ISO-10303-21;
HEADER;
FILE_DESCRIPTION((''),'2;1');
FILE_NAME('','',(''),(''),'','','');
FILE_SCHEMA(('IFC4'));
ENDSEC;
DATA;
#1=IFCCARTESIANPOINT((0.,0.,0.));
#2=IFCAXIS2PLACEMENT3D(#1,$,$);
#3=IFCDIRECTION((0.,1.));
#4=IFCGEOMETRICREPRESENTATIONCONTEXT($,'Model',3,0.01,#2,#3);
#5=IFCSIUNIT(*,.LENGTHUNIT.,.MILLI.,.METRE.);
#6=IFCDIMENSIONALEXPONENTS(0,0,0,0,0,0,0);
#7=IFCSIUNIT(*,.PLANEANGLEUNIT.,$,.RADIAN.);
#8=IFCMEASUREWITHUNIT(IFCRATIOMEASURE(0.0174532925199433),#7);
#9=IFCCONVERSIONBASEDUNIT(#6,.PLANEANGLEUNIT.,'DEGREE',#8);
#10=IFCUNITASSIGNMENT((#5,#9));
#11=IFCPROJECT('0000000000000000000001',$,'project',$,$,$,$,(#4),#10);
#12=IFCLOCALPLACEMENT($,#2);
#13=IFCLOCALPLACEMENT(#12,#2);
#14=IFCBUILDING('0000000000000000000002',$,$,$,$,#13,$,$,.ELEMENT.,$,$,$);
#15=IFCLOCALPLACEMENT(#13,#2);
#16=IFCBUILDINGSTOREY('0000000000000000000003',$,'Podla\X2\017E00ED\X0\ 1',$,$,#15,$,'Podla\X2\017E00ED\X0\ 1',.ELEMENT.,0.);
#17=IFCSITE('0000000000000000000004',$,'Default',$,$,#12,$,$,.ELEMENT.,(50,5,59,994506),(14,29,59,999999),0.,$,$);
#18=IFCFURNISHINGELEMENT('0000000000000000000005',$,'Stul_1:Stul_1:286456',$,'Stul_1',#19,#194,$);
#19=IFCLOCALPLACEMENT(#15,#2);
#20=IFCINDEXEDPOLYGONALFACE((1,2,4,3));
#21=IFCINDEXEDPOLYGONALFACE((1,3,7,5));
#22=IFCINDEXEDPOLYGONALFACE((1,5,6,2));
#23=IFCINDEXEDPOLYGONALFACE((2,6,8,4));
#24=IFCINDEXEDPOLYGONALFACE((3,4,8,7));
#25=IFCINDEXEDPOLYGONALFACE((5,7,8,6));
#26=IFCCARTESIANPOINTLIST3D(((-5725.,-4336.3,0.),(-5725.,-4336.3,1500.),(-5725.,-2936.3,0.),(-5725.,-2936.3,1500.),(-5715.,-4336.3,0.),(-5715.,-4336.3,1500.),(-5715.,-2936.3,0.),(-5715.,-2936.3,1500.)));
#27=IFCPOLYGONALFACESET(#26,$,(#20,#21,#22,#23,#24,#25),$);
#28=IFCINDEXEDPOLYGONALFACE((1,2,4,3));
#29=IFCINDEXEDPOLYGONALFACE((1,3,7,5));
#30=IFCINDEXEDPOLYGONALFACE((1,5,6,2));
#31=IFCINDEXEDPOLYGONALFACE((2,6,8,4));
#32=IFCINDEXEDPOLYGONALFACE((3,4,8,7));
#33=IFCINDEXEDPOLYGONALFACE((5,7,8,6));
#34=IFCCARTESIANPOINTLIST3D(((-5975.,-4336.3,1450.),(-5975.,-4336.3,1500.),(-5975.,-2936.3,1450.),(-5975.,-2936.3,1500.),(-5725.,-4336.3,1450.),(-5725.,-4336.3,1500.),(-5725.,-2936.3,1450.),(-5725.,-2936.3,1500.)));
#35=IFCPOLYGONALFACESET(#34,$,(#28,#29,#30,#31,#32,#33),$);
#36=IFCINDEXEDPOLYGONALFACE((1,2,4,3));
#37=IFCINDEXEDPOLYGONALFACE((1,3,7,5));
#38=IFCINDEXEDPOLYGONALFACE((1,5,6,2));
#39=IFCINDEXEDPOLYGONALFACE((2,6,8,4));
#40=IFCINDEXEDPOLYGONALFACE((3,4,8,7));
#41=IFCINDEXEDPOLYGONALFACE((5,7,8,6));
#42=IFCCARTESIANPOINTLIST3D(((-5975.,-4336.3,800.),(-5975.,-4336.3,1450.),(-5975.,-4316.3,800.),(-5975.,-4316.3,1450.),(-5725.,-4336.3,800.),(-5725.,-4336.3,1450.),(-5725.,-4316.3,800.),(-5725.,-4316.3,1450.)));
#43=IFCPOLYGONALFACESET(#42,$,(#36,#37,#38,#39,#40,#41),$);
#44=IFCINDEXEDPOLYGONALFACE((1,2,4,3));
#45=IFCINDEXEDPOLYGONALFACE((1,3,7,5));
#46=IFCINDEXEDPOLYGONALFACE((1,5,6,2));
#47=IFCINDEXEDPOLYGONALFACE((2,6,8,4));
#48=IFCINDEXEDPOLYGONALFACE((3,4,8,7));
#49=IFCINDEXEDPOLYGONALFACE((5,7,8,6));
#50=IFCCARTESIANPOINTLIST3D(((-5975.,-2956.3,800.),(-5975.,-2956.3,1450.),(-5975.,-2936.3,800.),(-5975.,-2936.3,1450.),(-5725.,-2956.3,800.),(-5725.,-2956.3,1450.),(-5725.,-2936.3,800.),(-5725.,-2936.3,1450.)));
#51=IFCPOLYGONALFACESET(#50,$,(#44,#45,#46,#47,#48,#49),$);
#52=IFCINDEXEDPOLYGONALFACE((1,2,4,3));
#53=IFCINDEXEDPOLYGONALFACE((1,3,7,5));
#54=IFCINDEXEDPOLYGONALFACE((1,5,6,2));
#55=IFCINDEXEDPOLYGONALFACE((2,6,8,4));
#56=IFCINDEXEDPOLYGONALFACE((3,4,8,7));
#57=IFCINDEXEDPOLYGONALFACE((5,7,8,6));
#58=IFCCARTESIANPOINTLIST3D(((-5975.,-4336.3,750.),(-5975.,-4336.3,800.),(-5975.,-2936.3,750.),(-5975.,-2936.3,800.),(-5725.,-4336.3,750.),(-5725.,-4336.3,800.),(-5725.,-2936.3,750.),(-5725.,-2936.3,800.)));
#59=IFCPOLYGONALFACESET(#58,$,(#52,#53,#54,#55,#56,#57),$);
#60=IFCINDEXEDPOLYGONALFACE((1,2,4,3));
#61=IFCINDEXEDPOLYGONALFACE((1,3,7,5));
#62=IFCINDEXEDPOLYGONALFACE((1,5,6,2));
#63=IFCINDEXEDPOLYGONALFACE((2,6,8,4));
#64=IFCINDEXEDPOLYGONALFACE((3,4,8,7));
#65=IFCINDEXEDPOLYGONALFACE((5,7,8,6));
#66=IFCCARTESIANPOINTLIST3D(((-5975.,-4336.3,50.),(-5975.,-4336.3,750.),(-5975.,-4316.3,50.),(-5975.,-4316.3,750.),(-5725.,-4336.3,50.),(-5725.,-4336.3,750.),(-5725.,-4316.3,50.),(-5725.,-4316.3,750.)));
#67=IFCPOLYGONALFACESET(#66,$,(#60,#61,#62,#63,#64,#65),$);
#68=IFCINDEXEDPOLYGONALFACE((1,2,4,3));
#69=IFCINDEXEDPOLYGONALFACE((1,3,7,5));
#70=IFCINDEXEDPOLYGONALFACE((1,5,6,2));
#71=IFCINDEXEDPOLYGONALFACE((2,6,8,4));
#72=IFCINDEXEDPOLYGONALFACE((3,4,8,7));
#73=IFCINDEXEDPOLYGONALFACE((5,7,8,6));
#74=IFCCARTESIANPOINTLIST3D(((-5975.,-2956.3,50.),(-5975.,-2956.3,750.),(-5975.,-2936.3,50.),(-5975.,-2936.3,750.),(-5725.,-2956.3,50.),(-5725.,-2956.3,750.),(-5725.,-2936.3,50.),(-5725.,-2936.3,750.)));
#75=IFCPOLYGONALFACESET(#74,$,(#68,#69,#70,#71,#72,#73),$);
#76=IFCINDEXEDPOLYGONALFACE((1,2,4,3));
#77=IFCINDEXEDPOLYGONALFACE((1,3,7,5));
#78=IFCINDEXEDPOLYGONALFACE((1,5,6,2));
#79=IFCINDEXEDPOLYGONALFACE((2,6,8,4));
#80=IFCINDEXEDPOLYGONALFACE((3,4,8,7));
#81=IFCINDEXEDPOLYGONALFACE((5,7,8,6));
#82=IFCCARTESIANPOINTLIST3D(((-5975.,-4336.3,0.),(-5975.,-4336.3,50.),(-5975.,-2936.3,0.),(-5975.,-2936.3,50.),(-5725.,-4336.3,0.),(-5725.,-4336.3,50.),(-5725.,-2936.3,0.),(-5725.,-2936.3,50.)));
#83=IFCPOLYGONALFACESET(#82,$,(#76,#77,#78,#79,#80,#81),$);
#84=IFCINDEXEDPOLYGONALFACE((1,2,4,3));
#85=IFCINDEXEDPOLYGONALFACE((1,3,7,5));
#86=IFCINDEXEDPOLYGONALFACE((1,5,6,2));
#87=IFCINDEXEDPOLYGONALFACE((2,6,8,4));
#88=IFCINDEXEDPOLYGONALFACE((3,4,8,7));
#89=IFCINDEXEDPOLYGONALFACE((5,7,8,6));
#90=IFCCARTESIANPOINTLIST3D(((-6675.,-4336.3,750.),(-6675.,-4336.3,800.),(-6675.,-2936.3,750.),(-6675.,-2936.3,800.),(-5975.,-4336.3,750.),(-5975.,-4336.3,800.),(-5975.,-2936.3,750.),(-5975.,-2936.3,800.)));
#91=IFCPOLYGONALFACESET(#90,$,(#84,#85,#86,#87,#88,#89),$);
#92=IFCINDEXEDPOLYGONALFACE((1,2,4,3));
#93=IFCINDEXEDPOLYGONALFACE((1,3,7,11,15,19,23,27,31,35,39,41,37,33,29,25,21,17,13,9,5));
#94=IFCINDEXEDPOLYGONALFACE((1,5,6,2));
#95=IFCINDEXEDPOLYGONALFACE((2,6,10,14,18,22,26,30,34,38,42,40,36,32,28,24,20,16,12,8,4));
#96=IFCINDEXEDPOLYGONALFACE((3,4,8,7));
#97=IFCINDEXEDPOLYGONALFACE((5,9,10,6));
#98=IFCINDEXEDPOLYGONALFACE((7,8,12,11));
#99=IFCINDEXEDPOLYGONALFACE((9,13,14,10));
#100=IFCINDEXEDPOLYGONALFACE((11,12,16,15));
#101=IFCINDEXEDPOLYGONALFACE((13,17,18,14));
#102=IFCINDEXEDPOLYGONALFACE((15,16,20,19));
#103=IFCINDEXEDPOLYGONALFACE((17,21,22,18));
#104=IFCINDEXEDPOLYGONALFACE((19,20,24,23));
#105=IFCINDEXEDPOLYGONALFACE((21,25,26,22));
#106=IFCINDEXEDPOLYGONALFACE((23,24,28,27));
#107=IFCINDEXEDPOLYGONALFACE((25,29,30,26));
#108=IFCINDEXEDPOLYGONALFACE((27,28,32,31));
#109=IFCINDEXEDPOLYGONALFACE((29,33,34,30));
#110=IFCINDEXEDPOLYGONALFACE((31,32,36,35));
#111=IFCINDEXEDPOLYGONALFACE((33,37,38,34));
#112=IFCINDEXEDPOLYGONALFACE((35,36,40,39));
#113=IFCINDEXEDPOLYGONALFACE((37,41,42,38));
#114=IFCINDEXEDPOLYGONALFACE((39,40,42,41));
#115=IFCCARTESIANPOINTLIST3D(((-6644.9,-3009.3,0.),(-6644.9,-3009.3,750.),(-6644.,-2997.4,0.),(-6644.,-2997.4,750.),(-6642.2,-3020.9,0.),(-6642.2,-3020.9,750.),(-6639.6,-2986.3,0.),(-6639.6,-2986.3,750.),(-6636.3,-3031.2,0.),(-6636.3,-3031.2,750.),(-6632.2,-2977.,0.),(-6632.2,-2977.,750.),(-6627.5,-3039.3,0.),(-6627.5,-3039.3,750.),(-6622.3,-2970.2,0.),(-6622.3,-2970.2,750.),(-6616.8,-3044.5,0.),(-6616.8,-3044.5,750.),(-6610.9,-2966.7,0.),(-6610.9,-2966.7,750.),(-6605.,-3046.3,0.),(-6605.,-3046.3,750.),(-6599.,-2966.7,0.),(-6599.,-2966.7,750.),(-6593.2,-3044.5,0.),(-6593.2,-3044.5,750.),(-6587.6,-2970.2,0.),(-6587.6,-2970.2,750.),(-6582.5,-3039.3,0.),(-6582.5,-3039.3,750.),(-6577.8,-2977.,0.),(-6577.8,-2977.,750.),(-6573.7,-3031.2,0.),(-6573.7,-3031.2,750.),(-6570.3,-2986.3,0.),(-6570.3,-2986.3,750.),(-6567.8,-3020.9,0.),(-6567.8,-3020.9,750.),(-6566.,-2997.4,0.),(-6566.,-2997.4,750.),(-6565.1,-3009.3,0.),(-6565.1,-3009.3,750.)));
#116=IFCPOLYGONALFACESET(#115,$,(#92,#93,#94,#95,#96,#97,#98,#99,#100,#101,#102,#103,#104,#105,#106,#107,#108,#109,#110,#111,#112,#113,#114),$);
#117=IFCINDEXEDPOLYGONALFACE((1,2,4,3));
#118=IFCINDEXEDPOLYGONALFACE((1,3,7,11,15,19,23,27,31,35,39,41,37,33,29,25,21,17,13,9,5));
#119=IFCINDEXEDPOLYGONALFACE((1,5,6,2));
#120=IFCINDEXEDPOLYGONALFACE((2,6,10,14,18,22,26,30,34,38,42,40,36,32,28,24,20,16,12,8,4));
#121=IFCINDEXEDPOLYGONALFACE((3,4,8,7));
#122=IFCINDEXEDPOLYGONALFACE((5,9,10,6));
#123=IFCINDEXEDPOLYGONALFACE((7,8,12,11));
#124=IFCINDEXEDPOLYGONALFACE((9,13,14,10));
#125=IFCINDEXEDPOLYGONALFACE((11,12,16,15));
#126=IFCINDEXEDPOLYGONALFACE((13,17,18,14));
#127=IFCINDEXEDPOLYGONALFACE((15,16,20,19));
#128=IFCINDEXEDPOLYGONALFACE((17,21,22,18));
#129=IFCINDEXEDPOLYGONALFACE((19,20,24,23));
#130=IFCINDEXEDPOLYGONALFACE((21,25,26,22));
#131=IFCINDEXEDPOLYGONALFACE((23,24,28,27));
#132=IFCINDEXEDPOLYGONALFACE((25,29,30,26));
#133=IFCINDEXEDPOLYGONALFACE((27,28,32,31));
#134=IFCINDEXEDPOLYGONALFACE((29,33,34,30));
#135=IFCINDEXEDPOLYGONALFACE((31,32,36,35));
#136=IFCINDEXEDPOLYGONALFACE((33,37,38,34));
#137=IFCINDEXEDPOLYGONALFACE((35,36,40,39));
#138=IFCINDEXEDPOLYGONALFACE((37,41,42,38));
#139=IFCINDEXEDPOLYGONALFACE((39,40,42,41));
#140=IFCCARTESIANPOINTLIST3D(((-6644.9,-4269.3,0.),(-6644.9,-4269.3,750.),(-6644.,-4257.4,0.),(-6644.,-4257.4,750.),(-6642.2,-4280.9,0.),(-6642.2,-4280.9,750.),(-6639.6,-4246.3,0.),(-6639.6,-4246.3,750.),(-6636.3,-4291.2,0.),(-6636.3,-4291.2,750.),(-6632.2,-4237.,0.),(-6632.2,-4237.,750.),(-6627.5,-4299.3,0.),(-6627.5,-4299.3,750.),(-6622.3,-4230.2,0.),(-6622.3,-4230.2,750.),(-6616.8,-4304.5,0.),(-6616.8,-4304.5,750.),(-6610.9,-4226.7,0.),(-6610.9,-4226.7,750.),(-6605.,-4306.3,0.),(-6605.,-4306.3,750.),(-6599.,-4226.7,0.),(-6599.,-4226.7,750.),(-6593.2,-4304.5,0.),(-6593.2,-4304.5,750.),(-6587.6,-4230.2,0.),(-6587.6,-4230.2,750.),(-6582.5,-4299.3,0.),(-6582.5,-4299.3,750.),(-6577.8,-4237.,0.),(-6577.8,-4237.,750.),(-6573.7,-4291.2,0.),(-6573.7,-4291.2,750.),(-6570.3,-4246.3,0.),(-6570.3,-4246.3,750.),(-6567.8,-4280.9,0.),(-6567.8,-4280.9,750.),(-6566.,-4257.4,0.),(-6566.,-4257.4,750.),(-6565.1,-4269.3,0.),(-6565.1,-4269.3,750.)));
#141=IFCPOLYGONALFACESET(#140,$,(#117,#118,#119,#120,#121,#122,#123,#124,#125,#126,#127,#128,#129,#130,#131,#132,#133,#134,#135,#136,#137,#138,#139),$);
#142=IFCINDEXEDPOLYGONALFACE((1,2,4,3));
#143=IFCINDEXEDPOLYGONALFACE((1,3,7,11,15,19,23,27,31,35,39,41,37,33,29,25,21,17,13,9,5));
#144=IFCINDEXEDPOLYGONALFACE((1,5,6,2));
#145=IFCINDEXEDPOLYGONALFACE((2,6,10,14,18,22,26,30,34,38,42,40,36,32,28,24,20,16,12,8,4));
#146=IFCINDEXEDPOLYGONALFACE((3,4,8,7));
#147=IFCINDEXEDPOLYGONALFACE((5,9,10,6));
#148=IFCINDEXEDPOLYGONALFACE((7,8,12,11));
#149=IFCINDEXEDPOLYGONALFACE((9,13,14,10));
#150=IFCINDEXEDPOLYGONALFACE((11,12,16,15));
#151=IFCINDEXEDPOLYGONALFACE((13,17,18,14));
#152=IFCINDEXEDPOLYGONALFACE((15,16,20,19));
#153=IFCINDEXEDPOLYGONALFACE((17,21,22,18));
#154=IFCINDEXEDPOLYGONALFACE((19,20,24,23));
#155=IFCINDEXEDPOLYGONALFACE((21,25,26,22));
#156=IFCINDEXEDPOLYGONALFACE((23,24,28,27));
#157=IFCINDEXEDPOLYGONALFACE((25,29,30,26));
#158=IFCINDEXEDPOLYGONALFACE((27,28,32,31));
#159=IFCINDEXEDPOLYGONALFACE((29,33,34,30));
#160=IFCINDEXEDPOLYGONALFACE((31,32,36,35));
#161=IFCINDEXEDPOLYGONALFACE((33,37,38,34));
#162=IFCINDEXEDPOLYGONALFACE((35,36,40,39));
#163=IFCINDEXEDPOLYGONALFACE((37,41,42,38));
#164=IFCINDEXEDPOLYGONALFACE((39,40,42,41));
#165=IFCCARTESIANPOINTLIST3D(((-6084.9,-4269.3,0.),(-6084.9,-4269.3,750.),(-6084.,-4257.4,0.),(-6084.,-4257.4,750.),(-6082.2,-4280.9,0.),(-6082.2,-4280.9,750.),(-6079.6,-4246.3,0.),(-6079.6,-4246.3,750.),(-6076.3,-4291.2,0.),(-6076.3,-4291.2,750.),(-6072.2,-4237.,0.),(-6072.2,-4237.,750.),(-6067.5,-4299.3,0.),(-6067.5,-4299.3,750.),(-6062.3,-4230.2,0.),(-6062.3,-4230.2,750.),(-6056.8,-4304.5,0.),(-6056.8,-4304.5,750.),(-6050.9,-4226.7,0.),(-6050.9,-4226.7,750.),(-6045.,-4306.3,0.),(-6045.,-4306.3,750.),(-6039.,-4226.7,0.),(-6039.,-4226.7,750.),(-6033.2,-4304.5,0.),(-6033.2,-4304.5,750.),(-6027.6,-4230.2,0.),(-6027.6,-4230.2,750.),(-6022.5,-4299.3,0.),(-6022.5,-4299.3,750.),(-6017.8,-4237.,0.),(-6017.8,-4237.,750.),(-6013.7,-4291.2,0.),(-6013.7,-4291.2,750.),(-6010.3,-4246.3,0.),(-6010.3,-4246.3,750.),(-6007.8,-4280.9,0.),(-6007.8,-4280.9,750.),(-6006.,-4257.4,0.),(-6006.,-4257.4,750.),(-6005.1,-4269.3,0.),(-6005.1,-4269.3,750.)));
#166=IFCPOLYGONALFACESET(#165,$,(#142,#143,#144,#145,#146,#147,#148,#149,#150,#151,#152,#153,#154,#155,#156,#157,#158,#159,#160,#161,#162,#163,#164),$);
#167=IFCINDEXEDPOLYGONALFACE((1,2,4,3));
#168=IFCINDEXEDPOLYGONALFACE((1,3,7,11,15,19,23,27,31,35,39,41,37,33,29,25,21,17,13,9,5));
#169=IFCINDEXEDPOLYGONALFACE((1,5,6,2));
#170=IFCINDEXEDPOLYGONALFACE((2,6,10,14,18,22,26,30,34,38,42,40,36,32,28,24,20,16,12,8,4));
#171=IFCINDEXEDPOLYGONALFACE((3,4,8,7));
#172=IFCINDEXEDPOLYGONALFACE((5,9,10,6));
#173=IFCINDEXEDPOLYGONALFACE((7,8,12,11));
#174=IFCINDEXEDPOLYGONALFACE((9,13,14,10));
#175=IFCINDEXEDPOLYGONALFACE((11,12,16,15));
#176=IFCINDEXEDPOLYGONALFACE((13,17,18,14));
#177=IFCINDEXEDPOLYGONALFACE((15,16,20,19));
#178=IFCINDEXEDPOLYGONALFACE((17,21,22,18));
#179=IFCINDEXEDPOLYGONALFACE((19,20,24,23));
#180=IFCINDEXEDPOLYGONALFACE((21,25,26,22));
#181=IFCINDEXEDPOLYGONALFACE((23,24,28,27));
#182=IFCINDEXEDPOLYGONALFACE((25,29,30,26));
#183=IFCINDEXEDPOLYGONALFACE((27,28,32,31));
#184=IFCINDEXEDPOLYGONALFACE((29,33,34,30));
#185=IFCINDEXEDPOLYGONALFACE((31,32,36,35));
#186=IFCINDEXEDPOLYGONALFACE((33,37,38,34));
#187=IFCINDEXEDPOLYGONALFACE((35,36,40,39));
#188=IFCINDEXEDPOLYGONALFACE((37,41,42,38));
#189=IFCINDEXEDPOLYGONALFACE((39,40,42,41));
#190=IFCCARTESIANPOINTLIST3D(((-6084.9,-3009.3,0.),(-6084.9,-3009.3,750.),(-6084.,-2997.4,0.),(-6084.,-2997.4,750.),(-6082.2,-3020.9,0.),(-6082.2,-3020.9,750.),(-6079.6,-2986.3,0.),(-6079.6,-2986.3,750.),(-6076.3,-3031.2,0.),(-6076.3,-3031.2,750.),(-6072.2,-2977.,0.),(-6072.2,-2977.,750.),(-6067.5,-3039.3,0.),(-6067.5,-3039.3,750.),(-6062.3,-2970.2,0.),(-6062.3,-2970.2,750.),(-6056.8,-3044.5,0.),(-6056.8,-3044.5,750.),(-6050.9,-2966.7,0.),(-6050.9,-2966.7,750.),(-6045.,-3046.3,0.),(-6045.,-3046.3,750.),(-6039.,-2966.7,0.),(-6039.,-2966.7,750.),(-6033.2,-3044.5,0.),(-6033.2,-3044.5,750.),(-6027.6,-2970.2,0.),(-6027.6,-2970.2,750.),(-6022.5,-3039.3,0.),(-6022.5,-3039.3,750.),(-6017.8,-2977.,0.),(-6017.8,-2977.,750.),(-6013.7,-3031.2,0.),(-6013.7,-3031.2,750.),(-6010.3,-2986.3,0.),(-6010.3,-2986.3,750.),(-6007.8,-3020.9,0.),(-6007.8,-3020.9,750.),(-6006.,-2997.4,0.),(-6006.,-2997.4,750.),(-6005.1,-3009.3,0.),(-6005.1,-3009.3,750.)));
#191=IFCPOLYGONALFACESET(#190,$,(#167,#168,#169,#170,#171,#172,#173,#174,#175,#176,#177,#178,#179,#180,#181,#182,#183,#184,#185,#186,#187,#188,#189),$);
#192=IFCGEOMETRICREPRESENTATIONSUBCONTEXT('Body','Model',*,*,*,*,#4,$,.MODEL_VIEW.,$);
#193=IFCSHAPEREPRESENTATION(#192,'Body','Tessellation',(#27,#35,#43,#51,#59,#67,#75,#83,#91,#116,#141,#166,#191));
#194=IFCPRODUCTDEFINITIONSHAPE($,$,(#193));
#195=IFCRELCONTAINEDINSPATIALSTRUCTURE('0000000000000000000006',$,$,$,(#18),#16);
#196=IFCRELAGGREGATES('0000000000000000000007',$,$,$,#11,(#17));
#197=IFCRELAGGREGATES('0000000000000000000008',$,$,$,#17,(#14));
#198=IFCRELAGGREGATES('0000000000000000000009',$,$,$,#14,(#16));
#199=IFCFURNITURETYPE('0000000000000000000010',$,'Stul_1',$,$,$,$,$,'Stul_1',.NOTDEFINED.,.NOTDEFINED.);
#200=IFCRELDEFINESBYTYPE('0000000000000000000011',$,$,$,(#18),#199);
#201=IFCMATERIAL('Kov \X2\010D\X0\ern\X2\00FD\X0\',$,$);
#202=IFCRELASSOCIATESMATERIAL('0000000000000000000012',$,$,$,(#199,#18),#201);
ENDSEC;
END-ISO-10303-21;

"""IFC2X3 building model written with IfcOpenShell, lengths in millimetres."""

from ifc_helpers import new_model, entity, si_unit, converted_unit, direction, frame, frame_2d, origin, origin_2d_with_axis, place, context, subcontext, project, spatial, rectangle, circle, extrude, source, transform, mapped, material, type_object, type_shapes, element, save


model = new_model("IFC2X3")

# Units and contexts
model_context = context("Model", 3, precision=0.01, world=origin(), true_north=direction((0.0, 1.0)))
body_context = subcontext(model_context, "Body", "Model", "MODEL_VIEW")
ifc_project = project(units=[si_unit("LENGTHUNIT", "METRE", prefix="MILLI"), converted_unit("PLANEANGLEUNIT", "DEGREE", entity("IfcRatioMeasure", 0.0174532925199433), si_unit("PLANEANGLEUNIT", "RADIAN"), dimensions=[0, 0, 0, 0, 0, 0, 0])], contexts=[model_context])

# Site, building, storey
site_placement = place(None, origin())
site = spatial("IfcSite", under=ifc_project, at=site_placement, Name="Default", CompositionType="ELEMENT", RefLatitude=(50, 5, 59, 994506), RefLongitude=(14, 29, 59, 999999), RefElevation=0.0)
building_placement = place(site_placement, origin())
building = spatial("IfcBuilding", under=site, at=building_placement, CompositionType="ELEMENT")
storey_placement = place(building_placement, origin())
storey = spatial("IfcBuildingStorey", under=building, at=storey_placement, Name="Podlaží 1", LongName="Podlaží 1", CompositionType="ELEMENT", Elevation=0.0)

# Furnishing element
ifc_material_1 = material(Name="Kov černý")
furniture_type = type_object("IfcFurnitureType", Name="Stul_1", ElementType="Stul_1", material=ifc_material_1)
shared_shape_1 = source(origin(), body_context, "Body", "SweptSolid", [
    extrude(rectangle(XDim=1400.0, YDim=10.0, at=origin_2d_with_axis()), frame((0.0, 605.0, 0.0), z_axis=(0.0, 0.0, 1.0), x_axis=(-1.0, 0.0, 0.0)), (0.0, 0.0, 1.0), 1500.0),
    extrude(rectangle(XDim=1400.0, YDim=250.0, at=frame_2d((0.0, 0.0), x_axis=(1.0, 0.0))), frame((0.0, 475.0, 1450.0), z_axis=(0.0, 0.0, 1.0), x_axis=(-1.0, 0.0, 0.0)), (0.0, 0.0, 1.0), 50.0),
    extrude(rectangle(XDim=20.0, YDim=250.0, at=origin_2d_with_axis()), frame((690.0, 475.0, 800.0), z_axis=(0.0, 0.0, 1.0), x_axis=(-1.0, 0.0, 0.0)), (0.0, 0.0, 1.0), 650.0),
    extrude(rectangle(XDim=20.0, YDim=250.0, at=frame_2d((0.0, 0.0), x_axis=(1.0, 0.0))), frame((-690.0, 475.0, 800.0), z_axis=(0.0, 0.0, 1.0), x_axis=(-1.0, 0.0, 0.0)), (0.0, 0.0, 1.0), 650.0),
    extrude(rectangle(XDim=1400.0, YDim=250.0, at=origin_2d_with_axis()), frame((0.0, 475.0, 750.0), z_axis=(0.0, 0.0, 1.0), x_axis=(-1.0, 0.0, 0.0)), (0.0, 0.0, 1.0), 50.0),
    extrude(rectangle(XDim=20.0, YDim=250.0, at=origin_2d_with_axis()), frame((690.0, 475.0, 50.0), z_axis=(0.0, 0.0, 1.0), x_axis=(-1.0, 0.0, 0.0)), (0.0, 0.0, 1.0), 700.0),
    extrude(rectangle(XDim=20.0, YDim=250.0, at=frame_2d((0.0, 0.0), x_axis=(1.0, 0.0))), frame((-690.0, 475.0, 50.0), z_axis=(0.0, 0.0, 1.0), x_axis=(-1.0, 0.0, 0.0)), (0.0, 0.0, 1.0), 700.0),
    extrude(rectangle(XDim=1400.0, YDim=250.0, at=origin_2d_with_axis()), frame((0.0, 475.0, 0.0), z_axis=(0.0, 0.0, 1.0), x_axis=(-1.0, 0.0, 0.0)), (0.0, 0.0, 1.0), 50.0),
    extrude(rectangle(XDim=1400.0, YDim=700.0, at=origin_2d_with_axis()), frame((0.0, 0.0, 750.0), z_axis=(0.0, 0.0, 1.0), x_axis=(-1.0, 0.0, 0.0)), (0.0, 0.0, 1.0), 50.0),
    extrude(circle(Radius=40.0, at=frame_2d((0.0, 0.0), x_axis=(1.0, 0.0))), frame((-630.0, -280.0, 0.0)), (0.0, 0.0, 1.0), 750.0),
    extrude(circle(Radius=40.0, at=frame_2d((0.0, 0.0), x_axis=(1.0, 0.0))), frame((630.0, -280.0, 0.0)), (0.0, 0.0, 1.0), 750.0),
    extrude(circle(Radius=40.0, at=frame_2d((0.0, 0.0), x_axis=(1.0, 0.0))), frame((630.0, 280.0, 0.0)), (0.0, 0.0, 1.0), 750.0),
    extrude(circle(Radius=40.0, at=frame_2d((0.0, 0.0), x_axis=(1.0, 0.0))), frame((-630.0, 280.0, 0.0)), (0.0, 0.0, 1.0), 750.0),
])
type_shapes(furniture_type, [shared_shape_1])
for number, where, z_axis, x_axis, name in (
    (1, (-6325.0, -3636.3, 0.0), (0.0, 0.0, 1.0), (0.0, -1.0, 0.0), "Stul_1:Stul_1:286456"),
):
    element("IfcFurnishingElement", number, at=place(storey_placement, frame(where, z_axis=z_axis, x_axis=x_axis)), inside=storey, type_object=furniture_type, material=ifc_material_1, Name=name, ObjectType="Stul_1", context=body_context, shape_type="MappedRepresentation", body=[
        mapped(shared_shape_1, transform((0.0, 0.0, 0.0), scale=1.0)),
    ])

save(model, "model.ifc")
